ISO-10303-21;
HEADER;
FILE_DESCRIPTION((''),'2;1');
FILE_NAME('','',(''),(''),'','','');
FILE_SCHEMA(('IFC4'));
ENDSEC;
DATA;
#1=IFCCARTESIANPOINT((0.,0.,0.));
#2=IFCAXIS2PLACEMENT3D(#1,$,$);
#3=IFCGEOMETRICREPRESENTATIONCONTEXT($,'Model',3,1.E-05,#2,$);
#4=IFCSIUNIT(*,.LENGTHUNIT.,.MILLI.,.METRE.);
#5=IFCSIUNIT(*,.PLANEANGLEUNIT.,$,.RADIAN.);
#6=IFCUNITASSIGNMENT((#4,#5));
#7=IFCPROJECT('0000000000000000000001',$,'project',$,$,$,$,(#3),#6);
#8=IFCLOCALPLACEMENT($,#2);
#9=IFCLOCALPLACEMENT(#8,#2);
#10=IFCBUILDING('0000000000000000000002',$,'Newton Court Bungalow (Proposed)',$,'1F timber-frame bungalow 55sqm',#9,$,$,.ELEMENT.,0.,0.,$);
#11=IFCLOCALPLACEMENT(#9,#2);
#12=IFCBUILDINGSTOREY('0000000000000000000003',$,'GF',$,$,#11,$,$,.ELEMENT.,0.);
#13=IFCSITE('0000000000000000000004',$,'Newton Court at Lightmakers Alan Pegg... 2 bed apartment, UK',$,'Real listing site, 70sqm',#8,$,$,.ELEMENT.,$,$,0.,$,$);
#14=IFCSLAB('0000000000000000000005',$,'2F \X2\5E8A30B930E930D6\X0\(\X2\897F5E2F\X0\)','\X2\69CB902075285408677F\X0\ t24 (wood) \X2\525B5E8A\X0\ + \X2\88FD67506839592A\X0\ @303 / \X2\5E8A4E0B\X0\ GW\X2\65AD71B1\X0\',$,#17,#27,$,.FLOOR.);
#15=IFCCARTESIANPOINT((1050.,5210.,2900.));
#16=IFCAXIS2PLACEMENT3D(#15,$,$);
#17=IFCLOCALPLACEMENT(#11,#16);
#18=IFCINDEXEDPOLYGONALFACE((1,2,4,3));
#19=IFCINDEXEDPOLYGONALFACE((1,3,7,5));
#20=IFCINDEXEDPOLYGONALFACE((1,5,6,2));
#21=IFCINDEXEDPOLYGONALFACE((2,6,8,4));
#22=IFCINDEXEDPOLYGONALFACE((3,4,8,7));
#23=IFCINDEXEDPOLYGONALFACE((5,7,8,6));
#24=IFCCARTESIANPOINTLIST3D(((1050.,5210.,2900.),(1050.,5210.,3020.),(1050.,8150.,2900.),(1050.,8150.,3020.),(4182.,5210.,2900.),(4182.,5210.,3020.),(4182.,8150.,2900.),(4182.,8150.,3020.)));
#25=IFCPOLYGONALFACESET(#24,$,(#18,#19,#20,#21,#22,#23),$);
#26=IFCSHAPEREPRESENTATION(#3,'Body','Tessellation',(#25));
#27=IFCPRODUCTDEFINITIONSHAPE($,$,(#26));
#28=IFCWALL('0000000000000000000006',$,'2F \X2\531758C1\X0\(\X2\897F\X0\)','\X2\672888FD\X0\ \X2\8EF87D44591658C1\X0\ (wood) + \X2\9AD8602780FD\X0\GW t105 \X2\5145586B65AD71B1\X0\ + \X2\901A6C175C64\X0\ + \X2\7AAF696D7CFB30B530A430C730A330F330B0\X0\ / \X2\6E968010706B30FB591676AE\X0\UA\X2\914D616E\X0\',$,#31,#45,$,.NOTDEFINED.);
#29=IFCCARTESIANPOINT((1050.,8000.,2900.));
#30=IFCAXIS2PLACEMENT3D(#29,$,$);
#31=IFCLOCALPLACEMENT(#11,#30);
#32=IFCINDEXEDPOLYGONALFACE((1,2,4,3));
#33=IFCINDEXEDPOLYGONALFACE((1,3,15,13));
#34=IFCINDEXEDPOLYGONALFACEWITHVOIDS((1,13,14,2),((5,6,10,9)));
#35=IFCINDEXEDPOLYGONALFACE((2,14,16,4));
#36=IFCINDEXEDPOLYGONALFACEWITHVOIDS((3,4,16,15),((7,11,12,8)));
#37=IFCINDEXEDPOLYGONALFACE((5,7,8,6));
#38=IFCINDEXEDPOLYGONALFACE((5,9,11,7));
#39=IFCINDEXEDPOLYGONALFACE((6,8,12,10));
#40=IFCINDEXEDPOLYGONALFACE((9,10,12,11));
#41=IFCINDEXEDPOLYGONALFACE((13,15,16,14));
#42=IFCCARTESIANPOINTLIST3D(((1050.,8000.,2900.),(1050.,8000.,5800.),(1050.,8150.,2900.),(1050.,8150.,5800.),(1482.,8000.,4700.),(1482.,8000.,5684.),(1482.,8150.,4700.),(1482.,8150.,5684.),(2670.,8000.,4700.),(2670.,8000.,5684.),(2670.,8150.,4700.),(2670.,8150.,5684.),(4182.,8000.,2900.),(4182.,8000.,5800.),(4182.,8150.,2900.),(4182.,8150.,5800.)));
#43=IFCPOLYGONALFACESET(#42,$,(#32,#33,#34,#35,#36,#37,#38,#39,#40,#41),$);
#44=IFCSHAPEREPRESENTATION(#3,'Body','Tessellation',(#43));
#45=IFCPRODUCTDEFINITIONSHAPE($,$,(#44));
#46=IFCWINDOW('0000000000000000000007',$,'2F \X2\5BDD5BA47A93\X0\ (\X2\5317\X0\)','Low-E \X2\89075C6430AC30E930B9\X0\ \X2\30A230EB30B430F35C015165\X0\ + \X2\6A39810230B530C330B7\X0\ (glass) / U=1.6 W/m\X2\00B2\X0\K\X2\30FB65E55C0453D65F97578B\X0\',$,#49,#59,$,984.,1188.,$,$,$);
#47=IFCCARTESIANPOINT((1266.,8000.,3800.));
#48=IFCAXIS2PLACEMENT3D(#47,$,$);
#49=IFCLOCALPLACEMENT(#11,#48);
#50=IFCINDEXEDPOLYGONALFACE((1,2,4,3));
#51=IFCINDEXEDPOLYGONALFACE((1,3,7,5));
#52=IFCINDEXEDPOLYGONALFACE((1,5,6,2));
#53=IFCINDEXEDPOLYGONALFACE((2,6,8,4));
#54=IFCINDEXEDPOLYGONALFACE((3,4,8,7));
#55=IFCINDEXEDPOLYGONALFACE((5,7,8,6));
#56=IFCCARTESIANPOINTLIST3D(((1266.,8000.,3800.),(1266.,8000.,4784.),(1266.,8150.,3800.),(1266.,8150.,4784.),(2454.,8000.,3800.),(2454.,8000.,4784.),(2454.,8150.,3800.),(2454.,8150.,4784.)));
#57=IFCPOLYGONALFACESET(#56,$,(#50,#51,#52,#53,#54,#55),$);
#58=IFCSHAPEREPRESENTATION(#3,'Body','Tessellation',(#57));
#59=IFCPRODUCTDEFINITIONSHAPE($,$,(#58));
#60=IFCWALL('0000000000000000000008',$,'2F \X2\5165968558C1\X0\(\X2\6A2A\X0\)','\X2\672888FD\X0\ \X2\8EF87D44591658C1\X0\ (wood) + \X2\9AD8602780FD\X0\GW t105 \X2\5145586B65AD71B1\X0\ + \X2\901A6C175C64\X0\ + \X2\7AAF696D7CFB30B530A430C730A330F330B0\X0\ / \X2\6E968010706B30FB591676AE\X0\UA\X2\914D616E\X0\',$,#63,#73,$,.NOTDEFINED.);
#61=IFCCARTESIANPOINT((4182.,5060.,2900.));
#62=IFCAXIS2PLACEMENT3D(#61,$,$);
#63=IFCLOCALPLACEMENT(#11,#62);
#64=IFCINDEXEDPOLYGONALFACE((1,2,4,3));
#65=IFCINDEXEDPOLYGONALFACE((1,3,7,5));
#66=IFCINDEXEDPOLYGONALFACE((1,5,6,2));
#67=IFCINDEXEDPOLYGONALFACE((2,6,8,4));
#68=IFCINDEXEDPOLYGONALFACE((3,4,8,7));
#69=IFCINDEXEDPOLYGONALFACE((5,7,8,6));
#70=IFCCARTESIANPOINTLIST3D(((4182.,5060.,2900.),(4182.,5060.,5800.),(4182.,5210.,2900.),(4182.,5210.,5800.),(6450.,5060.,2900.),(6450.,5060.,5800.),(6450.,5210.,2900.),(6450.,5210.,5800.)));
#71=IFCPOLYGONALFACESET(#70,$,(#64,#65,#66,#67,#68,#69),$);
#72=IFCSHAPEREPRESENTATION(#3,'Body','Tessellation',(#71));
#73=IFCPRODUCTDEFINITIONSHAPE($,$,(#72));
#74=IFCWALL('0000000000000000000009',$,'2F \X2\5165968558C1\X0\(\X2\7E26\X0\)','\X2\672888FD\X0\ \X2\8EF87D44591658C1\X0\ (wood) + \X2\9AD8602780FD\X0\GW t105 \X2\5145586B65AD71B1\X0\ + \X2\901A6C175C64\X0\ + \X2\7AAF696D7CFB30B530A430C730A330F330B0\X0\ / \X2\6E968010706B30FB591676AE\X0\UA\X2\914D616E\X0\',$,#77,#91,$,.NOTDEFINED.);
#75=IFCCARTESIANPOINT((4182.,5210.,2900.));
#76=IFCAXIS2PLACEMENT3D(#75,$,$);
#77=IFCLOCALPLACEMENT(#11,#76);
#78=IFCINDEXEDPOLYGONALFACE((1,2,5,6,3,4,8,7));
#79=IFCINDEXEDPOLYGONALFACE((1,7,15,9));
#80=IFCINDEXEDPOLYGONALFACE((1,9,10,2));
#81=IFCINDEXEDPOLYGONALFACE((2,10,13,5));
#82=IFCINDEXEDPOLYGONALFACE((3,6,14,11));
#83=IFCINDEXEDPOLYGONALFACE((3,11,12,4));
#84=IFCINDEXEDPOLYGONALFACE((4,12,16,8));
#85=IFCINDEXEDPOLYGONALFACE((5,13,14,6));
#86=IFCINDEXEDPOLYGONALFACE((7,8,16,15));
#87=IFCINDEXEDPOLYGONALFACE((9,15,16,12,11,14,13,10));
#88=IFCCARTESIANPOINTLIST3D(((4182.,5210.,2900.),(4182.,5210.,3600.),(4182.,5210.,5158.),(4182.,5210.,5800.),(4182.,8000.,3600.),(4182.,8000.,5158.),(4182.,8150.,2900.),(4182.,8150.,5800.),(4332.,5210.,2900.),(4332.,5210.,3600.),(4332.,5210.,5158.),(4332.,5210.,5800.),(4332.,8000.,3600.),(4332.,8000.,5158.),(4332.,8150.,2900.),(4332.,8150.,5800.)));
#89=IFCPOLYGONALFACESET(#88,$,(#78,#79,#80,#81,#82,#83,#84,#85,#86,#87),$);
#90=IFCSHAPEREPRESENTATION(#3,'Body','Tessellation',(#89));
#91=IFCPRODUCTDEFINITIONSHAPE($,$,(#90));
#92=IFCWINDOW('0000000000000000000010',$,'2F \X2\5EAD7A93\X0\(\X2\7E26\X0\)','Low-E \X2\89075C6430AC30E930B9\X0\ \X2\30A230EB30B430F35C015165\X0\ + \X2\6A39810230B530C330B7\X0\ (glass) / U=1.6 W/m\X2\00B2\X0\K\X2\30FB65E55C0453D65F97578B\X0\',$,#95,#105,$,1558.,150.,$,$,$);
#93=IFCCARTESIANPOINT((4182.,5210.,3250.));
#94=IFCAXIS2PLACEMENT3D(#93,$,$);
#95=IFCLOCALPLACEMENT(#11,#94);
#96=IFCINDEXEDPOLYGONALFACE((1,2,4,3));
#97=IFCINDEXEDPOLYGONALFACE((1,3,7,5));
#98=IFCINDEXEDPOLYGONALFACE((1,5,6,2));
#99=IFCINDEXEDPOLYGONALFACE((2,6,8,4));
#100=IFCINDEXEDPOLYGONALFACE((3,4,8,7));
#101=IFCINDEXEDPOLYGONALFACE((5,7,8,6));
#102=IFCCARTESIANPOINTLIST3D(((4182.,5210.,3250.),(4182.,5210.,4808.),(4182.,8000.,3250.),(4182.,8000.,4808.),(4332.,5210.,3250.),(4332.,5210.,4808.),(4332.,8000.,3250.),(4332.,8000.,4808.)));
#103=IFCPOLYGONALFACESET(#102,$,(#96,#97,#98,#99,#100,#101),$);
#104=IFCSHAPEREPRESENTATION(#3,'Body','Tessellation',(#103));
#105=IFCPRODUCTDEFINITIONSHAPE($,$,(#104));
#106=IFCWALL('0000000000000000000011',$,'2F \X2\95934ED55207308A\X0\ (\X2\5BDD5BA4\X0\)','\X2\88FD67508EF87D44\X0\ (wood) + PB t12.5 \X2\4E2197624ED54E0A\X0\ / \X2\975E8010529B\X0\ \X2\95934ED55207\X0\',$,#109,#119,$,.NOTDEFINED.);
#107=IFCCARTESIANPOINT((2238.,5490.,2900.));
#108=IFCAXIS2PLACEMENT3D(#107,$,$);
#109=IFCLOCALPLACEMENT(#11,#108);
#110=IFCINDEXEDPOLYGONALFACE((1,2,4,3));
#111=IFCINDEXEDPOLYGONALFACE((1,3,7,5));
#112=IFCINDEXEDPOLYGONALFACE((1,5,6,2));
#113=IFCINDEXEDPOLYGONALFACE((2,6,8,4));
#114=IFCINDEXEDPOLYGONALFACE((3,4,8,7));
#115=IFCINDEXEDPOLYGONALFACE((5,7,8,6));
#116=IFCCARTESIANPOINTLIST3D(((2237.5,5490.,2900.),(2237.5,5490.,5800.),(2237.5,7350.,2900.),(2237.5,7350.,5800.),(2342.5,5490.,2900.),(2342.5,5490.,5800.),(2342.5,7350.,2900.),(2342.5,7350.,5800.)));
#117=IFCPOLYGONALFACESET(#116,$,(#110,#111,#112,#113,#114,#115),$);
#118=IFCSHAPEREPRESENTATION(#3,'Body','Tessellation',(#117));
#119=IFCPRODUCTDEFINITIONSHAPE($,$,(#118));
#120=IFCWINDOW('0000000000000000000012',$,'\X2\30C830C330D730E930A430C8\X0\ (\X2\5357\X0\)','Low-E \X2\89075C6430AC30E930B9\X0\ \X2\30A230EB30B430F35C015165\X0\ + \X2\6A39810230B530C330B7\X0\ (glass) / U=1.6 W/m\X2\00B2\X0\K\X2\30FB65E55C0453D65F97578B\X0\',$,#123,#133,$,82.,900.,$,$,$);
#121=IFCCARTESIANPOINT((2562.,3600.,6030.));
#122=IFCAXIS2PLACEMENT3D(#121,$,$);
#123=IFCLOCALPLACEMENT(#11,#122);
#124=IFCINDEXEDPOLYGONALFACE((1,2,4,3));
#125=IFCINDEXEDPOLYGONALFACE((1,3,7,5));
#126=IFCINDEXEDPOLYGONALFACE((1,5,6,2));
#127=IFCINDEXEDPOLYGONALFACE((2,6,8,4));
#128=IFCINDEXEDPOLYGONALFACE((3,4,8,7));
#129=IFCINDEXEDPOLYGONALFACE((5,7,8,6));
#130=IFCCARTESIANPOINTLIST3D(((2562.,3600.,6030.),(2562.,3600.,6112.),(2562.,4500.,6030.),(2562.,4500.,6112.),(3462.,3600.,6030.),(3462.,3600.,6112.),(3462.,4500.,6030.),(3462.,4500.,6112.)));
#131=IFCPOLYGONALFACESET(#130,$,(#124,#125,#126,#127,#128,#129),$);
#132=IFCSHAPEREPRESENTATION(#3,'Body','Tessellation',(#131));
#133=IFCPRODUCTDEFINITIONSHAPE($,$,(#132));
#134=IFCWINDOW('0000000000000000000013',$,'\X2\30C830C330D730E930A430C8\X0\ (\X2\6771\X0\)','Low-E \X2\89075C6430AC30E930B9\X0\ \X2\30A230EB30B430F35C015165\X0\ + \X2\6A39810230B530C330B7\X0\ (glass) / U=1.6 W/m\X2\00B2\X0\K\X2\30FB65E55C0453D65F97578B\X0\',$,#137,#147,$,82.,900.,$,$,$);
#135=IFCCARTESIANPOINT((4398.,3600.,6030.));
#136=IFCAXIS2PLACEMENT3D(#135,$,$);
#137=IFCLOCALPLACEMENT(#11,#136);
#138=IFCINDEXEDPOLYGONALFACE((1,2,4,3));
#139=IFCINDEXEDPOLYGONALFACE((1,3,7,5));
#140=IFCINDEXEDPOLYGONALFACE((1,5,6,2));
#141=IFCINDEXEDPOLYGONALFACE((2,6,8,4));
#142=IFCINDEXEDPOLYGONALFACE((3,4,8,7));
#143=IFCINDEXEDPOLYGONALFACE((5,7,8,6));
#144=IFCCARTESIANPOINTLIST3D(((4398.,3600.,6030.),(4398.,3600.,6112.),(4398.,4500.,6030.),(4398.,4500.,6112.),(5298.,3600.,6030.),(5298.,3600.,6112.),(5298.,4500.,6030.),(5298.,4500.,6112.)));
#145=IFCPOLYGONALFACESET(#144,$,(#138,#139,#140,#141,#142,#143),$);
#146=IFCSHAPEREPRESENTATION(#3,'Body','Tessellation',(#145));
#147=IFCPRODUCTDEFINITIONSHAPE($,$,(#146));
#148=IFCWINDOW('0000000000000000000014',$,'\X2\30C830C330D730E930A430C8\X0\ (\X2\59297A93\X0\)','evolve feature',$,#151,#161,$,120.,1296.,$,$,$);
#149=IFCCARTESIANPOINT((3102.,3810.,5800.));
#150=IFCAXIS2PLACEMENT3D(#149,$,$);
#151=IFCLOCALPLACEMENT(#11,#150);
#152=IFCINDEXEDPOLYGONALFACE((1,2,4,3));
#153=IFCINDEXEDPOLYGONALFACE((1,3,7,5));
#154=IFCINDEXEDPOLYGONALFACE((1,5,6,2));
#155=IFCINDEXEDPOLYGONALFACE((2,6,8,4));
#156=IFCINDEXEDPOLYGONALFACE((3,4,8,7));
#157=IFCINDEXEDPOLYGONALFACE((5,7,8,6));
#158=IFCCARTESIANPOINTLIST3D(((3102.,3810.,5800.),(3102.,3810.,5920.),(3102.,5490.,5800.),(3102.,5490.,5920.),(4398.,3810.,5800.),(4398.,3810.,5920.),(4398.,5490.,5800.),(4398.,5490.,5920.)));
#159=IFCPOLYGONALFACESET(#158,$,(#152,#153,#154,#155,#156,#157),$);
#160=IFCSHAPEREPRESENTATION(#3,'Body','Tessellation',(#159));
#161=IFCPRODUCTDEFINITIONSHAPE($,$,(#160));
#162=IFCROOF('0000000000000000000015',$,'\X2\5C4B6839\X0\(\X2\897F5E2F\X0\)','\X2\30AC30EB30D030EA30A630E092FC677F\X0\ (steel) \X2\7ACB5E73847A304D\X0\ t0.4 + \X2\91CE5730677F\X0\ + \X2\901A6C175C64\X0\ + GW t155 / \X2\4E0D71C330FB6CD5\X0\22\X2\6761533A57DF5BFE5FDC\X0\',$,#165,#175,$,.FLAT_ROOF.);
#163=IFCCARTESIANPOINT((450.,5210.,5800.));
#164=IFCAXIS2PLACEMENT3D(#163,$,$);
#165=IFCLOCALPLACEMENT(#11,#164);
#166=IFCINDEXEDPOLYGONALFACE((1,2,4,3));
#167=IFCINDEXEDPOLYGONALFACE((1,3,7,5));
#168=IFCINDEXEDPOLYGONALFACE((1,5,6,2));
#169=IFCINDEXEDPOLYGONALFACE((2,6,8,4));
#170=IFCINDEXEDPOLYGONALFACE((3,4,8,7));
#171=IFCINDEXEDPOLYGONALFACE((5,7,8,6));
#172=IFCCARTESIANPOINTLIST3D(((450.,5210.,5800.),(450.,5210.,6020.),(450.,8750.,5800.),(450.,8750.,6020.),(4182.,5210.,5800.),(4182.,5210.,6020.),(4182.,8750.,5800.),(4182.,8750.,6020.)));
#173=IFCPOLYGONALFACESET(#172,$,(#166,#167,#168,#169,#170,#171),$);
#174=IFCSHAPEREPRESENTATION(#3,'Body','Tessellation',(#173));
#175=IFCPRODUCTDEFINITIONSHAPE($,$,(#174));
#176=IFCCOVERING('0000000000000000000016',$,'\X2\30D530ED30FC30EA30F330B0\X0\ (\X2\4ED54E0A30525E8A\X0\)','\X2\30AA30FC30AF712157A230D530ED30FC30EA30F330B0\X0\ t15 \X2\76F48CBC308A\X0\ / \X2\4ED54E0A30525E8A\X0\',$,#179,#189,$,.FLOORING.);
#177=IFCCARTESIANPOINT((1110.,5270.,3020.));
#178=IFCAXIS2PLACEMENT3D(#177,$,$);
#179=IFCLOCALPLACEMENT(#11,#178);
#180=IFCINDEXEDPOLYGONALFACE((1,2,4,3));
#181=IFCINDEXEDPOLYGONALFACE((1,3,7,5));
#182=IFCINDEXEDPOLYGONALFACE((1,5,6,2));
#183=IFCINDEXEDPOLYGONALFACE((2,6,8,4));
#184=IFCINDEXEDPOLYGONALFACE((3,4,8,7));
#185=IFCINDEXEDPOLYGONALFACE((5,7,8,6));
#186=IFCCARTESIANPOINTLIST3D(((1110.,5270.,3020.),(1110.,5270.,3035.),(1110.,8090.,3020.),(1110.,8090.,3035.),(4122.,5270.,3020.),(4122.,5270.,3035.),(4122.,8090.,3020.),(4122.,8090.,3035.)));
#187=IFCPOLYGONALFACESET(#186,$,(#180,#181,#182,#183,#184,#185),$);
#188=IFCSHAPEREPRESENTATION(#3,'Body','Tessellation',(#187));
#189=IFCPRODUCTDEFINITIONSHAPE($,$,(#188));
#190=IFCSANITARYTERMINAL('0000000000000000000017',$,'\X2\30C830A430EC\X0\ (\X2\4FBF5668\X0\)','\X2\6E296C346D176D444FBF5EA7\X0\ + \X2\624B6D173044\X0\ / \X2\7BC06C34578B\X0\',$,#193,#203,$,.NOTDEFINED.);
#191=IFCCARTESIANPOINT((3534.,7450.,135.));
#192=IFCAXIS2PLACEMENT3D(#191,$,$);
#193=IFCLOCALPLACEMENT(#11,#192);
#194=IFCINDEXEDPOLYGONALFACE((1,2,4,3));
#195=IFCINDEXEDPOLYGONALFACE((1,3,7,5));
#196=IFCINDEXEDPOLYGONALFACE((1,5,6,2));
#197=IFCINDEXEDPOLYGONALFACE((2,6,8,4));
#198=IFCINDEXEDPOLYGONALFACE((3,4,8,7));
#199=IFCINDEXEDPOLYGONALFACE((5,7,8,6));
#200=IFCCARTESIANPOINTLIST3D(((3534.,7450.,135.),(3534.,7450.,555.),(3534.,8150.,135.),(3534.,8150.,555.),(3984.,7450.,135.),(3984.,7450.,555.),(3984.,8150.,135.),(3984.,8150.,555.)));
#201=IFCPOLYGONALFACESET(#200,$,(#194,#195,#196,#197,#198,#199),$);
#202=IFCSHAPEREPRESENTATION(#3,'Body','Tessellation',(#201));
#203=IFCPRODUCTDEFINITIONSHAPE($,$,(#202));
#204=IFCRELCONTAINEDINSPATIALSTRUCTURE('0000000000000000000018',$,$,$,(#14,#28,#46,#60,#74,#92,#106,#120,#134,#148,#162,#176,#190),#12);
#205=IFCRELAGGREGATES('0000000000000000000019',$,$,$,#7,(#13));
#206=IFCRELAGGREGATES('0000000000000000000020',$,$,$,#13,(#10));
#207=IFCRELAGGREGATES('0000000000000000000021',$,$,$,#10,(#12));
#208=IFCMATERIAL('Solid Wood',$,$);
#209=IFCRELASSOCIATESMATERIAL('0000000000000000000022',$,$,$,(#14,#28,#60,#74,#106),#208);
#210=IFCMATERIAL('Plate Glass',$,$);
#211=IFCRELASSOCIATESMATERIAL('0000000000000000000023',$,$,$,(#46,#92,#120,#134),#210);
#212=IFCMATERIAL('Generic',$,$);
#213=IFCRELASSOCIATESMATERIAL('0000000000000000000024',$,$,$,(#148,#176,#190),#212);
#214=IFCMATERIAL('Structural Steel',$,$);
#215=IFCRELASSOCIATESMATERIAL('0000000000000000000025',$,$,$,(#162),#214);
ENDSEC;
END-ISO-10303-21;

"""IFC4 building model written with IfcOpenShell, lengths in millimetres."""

from ifc_helpers import new_model, si_unit, frame, frame_2d, origin, place, context, project, spatial, rectangle, extrude, material, element, fill, save


model = new_model("IFC4")

# Units and contexts
model_context = context("Model", 3, precision=1e-05, world=origin())
ifc_project = project(units=[si_unit("LENGTHUNIT", "METRE", prefix="MILLI"), si_unit("PLANEANGLEUNIT", "RADIAN")], contexts=[model_context])

# Site, building, storey
site_placement = place(None, origin())
site = spatial("IfcSite", under=ifc_project, at=site_placement, Name="Newton Court at Lightmakers Alan Pegg... 2 bed apartment, UK", ObjectType="Real listing site, 70sqm", CompositionType="ELEMENT", RefElevation=0.0)
building_placement = place(site_placement, origin())
building = spatial("IfcBuilding", under=site, at=building_placement, Name="Newton Court Bungalow (Proposed)", ObjectType="1F timber-frame bungalow 55sqm", CompositionType="ELEMENT", ElevationOfRefHeight=0.0, ElevationOfTerrain=0.0)
storey_placement = place(building_placement, origin())
storey = spatial("IfcBuildingStorey", under=building, at=storey_placement, Name="GF", CompositionType="ELEMENT", Elevation=0.0)

# Slab
ifc_material_1 = material(Name="Solid Wood")
slab_placement = place(storey_placement, frame((1050.0, 5210.0, 2900.0)))
element("IfcSlab", 1, at=slab_placement, inside=storey, material=ifc_material_1, Name="2F 床スラブ(西帯)", Description="構造用合板 t24 (wood) 剛床 + 製材根太 @303 / 床下 GW断熱", PredefinedType="FLOOR", context=model_context, shape_type="SweptSolid", body=[
    extrude(rectangle(XDim=3132.0, YDim=2940.0, at=frame_2d((1566.0, 1470.0))), frame((1050.0, 5210.0, 2900.0)), (0.0, 0.0, 1.0), 120.0),
])

# Wall, opening, window
wall_1_placement = place(storey_placement, frame((1050.0, 8000.0, 2900.0)))
wall_1 = element("IfcWall", 2, at=wall_1_placement, inside=storey, material=ifc_material_1, Name="2F 北壁(西)", Description="木製 軸組外壁 (wood) + 高性能GW t105 充填断熱 + 通気層 + 窯業系サイディング / 準耐火・外皮UA配慮", PredefinedType="NOTDEFINED", context=model_context, shape_type="SweptSolid", body=[
    extrude(rectangle(XDim=3132.0, YDim=150.0, at=frame_2d((1566.0, 75.0))), frame((1050.0, 8000.0, 2900.0)), (0.0, 0.0, 1.0), 2900.0),
])
opening_1_placement = place(storey_placement, frame((1266.0, 8000.0, 3800.0)))
opening_1 = element("IfcOpeningElement", 3, at=opening_1_placement, cuts=wall_1, PredefinedType="NOTDEFINED", context=model_context, shape_type="SweptSolid", body=[
    extrude(rectangle(XDim=1188.0, YDim=150.0, at=frame_2d((594.0, 75.0))), frame((1266.0, 8000.0, 3800.0)), (0.0, 0.0, 1.0), 984.0),
])
ifc_material_2 = material(Name="Plate Glass")
window_1_placement = place(storey_placement, frame((1266.0, 8000.0, 3800.0)))
window_1 = element("IfcWindow", 4, at=window_1_placement, inside=storey, material=ifc_material_2, Name="2F 寝室窓 (北)", Description="Low-E 複層ガラス アルゴン封入 + 樹脂サッシ (glass) / U=1.6 W/m²K・日射取得型", OverallHeight=984.0, OverallWidth=1188.0, context=model_context, shape_type="SweptSolid", body=[
    extrude(rectangle(XDim=1188.0, YDim=150.0, at=frame_2d((594.0, 75.0))), frame((1266.0, 8000.0, 3800.0)), (0.0, 0.0, 1.0), 984.0),
])
fill(opening_1, window_1)

# Wall
wall_2_placement = place(storey_placement, frame((4182.0, 5060.0, 2900.0)))
element("IfcWall", 5, at=wall_2_placement, inside=storey, material=ifc_material_1, Name="2F 入隅壁(横)", Description="木製 軸組外壁 (wood) + 高性能GW t105 充填断熱 + 通気層 + 窯業系サイディング / 準耐火・外皮UA配慮", PredefinedType="NOTDEFINED", context=model_context, shape_type="SweptSolid", body=[
    extrude(rectangle(XDim=2268.0, YDim=150.0, at=frame_2d((1134.0, 75.0))), frame((4182.0, 5060.0, 2900.0)), (0.0, 0.0, 1.0), 2900.0),
])

# Wall, opening, window
wall_3_placement = place(storey_placement, frame((4182.0, 5210.0, 2900.0)))
wall_3 = element("IfcWall", 6, at=wall_3_placement, inside=storey, material=ifc_material_1, Name="2F 入隅壁(縦)", Description="木製 軸組外壁 (wood) + 高性能GW t105 充填断熱 + 通気層 + 窯業系サイディング / 準耐火・外皮UA配慮", PredefinedType="NOTDEFINED", context=model_context, shape_type="SweptSolid", body=[
    extrude(rectangle(XDim=150.0, YDim=2940.0, at=frame_2d((75.0, 1470.0))), frame((4182.0, 5210.0, 2900.0)), (0.0, 0.0, 1.0), 2900.0),
])
opening_2_placement = place(storey_placement, frame((4182.0, 5210.0, 3250.0)))
opening_2 = element("IfcOpeningElement", 7, at=opening_2_placement, cuts=wall_3, PredefinedType="NOTDEFINED", context=model_context, shape_type="SweptSolid", body=[
    extrude(rectangle(XDim=150.0, YDim=2790.0, at=frame_2d((75.0, 1395.0))), frame((4182.0, 5210.0, 3250.0)), (0.0, 0.0, 1.0), 1558.0),
])
window_2_placement = place(storey_placement, frame((4182.0, 5210.0, 3250.0)))
window_2 = element("IfcWindow", 8, at=window_2_placement, inside=storey, material=ifc_material_2, Name="2F 庭窓(縦)", Description="Low-E 複層ガラス アルゴン封入 + 樹脂サッシ (glass) / U=1.6 W/m²K・日射取得型", OverallHeight=1558.0, OverallWidth=150.0, context=model_context, shape_type="SweptSolid", body=[
    extrude(rectangle(XDim=150.0, YDim=2790.0, at=frame_2d((75.0, 1395.0))), frame((4182.0, 5210.0, 3250.0)), (0.0, 0.0, 1.0), 1558.0),
])
fill(opening_2, window_2)

# Wall
wall_4_placement = place(storey_placement, frame((2238.0, 5490.0, 2900.0)))
element("IfcWall", 9, at=wall_4_placement, inside=storey, material=ifc_material_1, Name="2F 間仕切り (寝室)", Description="製材軸組 (wood) + PB t12.5 両面仕上 / 非耐力 間仕切", PredefinedType="NOTDEFINED", context=model_context, shape_type="SweptSolid", body=[
    extrude(rectangle(XDim=105.0, YDim=1860.0, at=frame_2d((52.0, 930.0))), frame((2238.0, 5490.0, 2900.0)), (0.0, 0.0, 1.0), 2900.0),
])

# Windows
window_3_placement = place(storey_placement, frame((2562.0, 3600.0, 6030.0)))
element("IfcWindow", 10, at=window_3_placement, inside=storey, material=ifc_material_2, Name="トップライト (南)", Description="Low-E 複層ガラス アルゴン封入 + 樹脂サッシ (glass) / U=1.6 W/m²K・日射取得型", OverallHeight=82.0, OverallWidth=900.0, context=model_context, shape_type="SweptSolid", body=[
    extrude(rectangle(XDim=900.0, YDim=900.0, at=frame_2d((450.0, 450.0))), frame((2562.0, 3600.0, 6030.0)), (0.0, 0.0, 1.0), 82.0),
])
window_4_placement = place(storey_placement, frame((4398.0, 3600.0, 6030.0)))
element("IfcWindow", 11, at=window_4_placement, inside=storey, material=ifc_material_2, Name="トップライト (東)", Description="Low-E 複層ガラス アルゴン封入 + 樹脂サッシ (glass) / U=1.6 W/m²K・日射取得型", OverallHeight=82.0, OverallWidth=900.0, context=model_context, shape_type="SweptSolid", body=[
    extrude(rectangle(XDim=900.0, YDim=900.0, at=frame_2d((450.0, 450.0))), frame((4398.0, 3600.0, 6030.0)), (0.0, 0.0, 1.0), 82.0),
])
ifc_material_3 = material(Name="Generic")
window_5_placement = place(storey_placement, frame((3102.0, 3810.0, 5800.0)))
element("IfcWindow", 12, at=window_5_placement, inside=storey, material=ifc_material_3, Name="トップライト (天窓)", Description="evolve feature", OverallHeight=120.0, OverallWidth=1296.0, context=model_context, shape_type="SweptSolid", body=[
    extrude(rectangle(XDim=1296.0, YDim=1680.0, at=frame_2d((648.0, 840.0))), frame((3102.0, 3810.0, 5800.0)), (0.0, 0.0, 1.0), 120.0),
])

# Roof
ifc_material_4 = material(Name="Structural Steel")
for number, where, name in (
    (13, (450.0, 5210.0, 5800.0), "屋根(西帯)"),
):
    element("IfcRoof", number, at=place(storey_placement, frame(where)), inside=storey, material=ifc_material_4, Name=name, Description="ガルバリウム鋼板 (steel) 立平葺き t0.4 + 野地板 + 通気層 + GW t155 / 不燃・法22条区域対応", PredefinedType="FLAT_ROOF", context=model_context, shape_type="SweptSolid", body=[
        extrude(rectangle(XDim=3732.0, YDim=3540.0, at=frame_2d((1866.0, 1770.0))), frame((450.0, 5210.0, 5800.0)), (0.0, 0.0, 1.0), 220.0),
    ])

# Covering
covering_placement = place(storey_placement, frame((1110.0, 5270.0, 3020.0)))
element("IfcCovering", 14, at=covering_placement, inside=storey, material=ifc_material_3, Name="フローリング (仕上げ床)", Description="オーク無垢フローリング t15 直貼り / 仕上げ床", PredefinedType="FLOORING", context=model_context, shape_type="SweptSolid", body=[
    extrude(rectangle(XDim=3012.0, YDim=2820.0, at=frame_2d((1506.0, 1410.0))), frame((1110.0, 5270.0, 3020.0)), (0.0, 0.0, 1.0), 15.0),
])

# Sanitary terminal
sanitary_terminal_placement = place(storey_placement, frame((3534.0, 7450.0, 135.0)))
element("IfcSanitaryTerminal", 15, at=sanitary_terminal_placement, inside=storey, material=ifc_material_3, Name="トイレ (便器)", Description="温水洗浄便座 + 手洗い / 節水型", PredefinedType="NOTDEFINED", context=model_context, shape_type="SweptSolid", body=[
    extrude(rectangle(XDim=450.0, YDim=700.0, at=frame_2d((225.0, 350.0))), frame((3534.0, 7450.0, 135.0)), (0.0, 0.0, 1.0), 420.0),
])

save(model, "model.ifc")
